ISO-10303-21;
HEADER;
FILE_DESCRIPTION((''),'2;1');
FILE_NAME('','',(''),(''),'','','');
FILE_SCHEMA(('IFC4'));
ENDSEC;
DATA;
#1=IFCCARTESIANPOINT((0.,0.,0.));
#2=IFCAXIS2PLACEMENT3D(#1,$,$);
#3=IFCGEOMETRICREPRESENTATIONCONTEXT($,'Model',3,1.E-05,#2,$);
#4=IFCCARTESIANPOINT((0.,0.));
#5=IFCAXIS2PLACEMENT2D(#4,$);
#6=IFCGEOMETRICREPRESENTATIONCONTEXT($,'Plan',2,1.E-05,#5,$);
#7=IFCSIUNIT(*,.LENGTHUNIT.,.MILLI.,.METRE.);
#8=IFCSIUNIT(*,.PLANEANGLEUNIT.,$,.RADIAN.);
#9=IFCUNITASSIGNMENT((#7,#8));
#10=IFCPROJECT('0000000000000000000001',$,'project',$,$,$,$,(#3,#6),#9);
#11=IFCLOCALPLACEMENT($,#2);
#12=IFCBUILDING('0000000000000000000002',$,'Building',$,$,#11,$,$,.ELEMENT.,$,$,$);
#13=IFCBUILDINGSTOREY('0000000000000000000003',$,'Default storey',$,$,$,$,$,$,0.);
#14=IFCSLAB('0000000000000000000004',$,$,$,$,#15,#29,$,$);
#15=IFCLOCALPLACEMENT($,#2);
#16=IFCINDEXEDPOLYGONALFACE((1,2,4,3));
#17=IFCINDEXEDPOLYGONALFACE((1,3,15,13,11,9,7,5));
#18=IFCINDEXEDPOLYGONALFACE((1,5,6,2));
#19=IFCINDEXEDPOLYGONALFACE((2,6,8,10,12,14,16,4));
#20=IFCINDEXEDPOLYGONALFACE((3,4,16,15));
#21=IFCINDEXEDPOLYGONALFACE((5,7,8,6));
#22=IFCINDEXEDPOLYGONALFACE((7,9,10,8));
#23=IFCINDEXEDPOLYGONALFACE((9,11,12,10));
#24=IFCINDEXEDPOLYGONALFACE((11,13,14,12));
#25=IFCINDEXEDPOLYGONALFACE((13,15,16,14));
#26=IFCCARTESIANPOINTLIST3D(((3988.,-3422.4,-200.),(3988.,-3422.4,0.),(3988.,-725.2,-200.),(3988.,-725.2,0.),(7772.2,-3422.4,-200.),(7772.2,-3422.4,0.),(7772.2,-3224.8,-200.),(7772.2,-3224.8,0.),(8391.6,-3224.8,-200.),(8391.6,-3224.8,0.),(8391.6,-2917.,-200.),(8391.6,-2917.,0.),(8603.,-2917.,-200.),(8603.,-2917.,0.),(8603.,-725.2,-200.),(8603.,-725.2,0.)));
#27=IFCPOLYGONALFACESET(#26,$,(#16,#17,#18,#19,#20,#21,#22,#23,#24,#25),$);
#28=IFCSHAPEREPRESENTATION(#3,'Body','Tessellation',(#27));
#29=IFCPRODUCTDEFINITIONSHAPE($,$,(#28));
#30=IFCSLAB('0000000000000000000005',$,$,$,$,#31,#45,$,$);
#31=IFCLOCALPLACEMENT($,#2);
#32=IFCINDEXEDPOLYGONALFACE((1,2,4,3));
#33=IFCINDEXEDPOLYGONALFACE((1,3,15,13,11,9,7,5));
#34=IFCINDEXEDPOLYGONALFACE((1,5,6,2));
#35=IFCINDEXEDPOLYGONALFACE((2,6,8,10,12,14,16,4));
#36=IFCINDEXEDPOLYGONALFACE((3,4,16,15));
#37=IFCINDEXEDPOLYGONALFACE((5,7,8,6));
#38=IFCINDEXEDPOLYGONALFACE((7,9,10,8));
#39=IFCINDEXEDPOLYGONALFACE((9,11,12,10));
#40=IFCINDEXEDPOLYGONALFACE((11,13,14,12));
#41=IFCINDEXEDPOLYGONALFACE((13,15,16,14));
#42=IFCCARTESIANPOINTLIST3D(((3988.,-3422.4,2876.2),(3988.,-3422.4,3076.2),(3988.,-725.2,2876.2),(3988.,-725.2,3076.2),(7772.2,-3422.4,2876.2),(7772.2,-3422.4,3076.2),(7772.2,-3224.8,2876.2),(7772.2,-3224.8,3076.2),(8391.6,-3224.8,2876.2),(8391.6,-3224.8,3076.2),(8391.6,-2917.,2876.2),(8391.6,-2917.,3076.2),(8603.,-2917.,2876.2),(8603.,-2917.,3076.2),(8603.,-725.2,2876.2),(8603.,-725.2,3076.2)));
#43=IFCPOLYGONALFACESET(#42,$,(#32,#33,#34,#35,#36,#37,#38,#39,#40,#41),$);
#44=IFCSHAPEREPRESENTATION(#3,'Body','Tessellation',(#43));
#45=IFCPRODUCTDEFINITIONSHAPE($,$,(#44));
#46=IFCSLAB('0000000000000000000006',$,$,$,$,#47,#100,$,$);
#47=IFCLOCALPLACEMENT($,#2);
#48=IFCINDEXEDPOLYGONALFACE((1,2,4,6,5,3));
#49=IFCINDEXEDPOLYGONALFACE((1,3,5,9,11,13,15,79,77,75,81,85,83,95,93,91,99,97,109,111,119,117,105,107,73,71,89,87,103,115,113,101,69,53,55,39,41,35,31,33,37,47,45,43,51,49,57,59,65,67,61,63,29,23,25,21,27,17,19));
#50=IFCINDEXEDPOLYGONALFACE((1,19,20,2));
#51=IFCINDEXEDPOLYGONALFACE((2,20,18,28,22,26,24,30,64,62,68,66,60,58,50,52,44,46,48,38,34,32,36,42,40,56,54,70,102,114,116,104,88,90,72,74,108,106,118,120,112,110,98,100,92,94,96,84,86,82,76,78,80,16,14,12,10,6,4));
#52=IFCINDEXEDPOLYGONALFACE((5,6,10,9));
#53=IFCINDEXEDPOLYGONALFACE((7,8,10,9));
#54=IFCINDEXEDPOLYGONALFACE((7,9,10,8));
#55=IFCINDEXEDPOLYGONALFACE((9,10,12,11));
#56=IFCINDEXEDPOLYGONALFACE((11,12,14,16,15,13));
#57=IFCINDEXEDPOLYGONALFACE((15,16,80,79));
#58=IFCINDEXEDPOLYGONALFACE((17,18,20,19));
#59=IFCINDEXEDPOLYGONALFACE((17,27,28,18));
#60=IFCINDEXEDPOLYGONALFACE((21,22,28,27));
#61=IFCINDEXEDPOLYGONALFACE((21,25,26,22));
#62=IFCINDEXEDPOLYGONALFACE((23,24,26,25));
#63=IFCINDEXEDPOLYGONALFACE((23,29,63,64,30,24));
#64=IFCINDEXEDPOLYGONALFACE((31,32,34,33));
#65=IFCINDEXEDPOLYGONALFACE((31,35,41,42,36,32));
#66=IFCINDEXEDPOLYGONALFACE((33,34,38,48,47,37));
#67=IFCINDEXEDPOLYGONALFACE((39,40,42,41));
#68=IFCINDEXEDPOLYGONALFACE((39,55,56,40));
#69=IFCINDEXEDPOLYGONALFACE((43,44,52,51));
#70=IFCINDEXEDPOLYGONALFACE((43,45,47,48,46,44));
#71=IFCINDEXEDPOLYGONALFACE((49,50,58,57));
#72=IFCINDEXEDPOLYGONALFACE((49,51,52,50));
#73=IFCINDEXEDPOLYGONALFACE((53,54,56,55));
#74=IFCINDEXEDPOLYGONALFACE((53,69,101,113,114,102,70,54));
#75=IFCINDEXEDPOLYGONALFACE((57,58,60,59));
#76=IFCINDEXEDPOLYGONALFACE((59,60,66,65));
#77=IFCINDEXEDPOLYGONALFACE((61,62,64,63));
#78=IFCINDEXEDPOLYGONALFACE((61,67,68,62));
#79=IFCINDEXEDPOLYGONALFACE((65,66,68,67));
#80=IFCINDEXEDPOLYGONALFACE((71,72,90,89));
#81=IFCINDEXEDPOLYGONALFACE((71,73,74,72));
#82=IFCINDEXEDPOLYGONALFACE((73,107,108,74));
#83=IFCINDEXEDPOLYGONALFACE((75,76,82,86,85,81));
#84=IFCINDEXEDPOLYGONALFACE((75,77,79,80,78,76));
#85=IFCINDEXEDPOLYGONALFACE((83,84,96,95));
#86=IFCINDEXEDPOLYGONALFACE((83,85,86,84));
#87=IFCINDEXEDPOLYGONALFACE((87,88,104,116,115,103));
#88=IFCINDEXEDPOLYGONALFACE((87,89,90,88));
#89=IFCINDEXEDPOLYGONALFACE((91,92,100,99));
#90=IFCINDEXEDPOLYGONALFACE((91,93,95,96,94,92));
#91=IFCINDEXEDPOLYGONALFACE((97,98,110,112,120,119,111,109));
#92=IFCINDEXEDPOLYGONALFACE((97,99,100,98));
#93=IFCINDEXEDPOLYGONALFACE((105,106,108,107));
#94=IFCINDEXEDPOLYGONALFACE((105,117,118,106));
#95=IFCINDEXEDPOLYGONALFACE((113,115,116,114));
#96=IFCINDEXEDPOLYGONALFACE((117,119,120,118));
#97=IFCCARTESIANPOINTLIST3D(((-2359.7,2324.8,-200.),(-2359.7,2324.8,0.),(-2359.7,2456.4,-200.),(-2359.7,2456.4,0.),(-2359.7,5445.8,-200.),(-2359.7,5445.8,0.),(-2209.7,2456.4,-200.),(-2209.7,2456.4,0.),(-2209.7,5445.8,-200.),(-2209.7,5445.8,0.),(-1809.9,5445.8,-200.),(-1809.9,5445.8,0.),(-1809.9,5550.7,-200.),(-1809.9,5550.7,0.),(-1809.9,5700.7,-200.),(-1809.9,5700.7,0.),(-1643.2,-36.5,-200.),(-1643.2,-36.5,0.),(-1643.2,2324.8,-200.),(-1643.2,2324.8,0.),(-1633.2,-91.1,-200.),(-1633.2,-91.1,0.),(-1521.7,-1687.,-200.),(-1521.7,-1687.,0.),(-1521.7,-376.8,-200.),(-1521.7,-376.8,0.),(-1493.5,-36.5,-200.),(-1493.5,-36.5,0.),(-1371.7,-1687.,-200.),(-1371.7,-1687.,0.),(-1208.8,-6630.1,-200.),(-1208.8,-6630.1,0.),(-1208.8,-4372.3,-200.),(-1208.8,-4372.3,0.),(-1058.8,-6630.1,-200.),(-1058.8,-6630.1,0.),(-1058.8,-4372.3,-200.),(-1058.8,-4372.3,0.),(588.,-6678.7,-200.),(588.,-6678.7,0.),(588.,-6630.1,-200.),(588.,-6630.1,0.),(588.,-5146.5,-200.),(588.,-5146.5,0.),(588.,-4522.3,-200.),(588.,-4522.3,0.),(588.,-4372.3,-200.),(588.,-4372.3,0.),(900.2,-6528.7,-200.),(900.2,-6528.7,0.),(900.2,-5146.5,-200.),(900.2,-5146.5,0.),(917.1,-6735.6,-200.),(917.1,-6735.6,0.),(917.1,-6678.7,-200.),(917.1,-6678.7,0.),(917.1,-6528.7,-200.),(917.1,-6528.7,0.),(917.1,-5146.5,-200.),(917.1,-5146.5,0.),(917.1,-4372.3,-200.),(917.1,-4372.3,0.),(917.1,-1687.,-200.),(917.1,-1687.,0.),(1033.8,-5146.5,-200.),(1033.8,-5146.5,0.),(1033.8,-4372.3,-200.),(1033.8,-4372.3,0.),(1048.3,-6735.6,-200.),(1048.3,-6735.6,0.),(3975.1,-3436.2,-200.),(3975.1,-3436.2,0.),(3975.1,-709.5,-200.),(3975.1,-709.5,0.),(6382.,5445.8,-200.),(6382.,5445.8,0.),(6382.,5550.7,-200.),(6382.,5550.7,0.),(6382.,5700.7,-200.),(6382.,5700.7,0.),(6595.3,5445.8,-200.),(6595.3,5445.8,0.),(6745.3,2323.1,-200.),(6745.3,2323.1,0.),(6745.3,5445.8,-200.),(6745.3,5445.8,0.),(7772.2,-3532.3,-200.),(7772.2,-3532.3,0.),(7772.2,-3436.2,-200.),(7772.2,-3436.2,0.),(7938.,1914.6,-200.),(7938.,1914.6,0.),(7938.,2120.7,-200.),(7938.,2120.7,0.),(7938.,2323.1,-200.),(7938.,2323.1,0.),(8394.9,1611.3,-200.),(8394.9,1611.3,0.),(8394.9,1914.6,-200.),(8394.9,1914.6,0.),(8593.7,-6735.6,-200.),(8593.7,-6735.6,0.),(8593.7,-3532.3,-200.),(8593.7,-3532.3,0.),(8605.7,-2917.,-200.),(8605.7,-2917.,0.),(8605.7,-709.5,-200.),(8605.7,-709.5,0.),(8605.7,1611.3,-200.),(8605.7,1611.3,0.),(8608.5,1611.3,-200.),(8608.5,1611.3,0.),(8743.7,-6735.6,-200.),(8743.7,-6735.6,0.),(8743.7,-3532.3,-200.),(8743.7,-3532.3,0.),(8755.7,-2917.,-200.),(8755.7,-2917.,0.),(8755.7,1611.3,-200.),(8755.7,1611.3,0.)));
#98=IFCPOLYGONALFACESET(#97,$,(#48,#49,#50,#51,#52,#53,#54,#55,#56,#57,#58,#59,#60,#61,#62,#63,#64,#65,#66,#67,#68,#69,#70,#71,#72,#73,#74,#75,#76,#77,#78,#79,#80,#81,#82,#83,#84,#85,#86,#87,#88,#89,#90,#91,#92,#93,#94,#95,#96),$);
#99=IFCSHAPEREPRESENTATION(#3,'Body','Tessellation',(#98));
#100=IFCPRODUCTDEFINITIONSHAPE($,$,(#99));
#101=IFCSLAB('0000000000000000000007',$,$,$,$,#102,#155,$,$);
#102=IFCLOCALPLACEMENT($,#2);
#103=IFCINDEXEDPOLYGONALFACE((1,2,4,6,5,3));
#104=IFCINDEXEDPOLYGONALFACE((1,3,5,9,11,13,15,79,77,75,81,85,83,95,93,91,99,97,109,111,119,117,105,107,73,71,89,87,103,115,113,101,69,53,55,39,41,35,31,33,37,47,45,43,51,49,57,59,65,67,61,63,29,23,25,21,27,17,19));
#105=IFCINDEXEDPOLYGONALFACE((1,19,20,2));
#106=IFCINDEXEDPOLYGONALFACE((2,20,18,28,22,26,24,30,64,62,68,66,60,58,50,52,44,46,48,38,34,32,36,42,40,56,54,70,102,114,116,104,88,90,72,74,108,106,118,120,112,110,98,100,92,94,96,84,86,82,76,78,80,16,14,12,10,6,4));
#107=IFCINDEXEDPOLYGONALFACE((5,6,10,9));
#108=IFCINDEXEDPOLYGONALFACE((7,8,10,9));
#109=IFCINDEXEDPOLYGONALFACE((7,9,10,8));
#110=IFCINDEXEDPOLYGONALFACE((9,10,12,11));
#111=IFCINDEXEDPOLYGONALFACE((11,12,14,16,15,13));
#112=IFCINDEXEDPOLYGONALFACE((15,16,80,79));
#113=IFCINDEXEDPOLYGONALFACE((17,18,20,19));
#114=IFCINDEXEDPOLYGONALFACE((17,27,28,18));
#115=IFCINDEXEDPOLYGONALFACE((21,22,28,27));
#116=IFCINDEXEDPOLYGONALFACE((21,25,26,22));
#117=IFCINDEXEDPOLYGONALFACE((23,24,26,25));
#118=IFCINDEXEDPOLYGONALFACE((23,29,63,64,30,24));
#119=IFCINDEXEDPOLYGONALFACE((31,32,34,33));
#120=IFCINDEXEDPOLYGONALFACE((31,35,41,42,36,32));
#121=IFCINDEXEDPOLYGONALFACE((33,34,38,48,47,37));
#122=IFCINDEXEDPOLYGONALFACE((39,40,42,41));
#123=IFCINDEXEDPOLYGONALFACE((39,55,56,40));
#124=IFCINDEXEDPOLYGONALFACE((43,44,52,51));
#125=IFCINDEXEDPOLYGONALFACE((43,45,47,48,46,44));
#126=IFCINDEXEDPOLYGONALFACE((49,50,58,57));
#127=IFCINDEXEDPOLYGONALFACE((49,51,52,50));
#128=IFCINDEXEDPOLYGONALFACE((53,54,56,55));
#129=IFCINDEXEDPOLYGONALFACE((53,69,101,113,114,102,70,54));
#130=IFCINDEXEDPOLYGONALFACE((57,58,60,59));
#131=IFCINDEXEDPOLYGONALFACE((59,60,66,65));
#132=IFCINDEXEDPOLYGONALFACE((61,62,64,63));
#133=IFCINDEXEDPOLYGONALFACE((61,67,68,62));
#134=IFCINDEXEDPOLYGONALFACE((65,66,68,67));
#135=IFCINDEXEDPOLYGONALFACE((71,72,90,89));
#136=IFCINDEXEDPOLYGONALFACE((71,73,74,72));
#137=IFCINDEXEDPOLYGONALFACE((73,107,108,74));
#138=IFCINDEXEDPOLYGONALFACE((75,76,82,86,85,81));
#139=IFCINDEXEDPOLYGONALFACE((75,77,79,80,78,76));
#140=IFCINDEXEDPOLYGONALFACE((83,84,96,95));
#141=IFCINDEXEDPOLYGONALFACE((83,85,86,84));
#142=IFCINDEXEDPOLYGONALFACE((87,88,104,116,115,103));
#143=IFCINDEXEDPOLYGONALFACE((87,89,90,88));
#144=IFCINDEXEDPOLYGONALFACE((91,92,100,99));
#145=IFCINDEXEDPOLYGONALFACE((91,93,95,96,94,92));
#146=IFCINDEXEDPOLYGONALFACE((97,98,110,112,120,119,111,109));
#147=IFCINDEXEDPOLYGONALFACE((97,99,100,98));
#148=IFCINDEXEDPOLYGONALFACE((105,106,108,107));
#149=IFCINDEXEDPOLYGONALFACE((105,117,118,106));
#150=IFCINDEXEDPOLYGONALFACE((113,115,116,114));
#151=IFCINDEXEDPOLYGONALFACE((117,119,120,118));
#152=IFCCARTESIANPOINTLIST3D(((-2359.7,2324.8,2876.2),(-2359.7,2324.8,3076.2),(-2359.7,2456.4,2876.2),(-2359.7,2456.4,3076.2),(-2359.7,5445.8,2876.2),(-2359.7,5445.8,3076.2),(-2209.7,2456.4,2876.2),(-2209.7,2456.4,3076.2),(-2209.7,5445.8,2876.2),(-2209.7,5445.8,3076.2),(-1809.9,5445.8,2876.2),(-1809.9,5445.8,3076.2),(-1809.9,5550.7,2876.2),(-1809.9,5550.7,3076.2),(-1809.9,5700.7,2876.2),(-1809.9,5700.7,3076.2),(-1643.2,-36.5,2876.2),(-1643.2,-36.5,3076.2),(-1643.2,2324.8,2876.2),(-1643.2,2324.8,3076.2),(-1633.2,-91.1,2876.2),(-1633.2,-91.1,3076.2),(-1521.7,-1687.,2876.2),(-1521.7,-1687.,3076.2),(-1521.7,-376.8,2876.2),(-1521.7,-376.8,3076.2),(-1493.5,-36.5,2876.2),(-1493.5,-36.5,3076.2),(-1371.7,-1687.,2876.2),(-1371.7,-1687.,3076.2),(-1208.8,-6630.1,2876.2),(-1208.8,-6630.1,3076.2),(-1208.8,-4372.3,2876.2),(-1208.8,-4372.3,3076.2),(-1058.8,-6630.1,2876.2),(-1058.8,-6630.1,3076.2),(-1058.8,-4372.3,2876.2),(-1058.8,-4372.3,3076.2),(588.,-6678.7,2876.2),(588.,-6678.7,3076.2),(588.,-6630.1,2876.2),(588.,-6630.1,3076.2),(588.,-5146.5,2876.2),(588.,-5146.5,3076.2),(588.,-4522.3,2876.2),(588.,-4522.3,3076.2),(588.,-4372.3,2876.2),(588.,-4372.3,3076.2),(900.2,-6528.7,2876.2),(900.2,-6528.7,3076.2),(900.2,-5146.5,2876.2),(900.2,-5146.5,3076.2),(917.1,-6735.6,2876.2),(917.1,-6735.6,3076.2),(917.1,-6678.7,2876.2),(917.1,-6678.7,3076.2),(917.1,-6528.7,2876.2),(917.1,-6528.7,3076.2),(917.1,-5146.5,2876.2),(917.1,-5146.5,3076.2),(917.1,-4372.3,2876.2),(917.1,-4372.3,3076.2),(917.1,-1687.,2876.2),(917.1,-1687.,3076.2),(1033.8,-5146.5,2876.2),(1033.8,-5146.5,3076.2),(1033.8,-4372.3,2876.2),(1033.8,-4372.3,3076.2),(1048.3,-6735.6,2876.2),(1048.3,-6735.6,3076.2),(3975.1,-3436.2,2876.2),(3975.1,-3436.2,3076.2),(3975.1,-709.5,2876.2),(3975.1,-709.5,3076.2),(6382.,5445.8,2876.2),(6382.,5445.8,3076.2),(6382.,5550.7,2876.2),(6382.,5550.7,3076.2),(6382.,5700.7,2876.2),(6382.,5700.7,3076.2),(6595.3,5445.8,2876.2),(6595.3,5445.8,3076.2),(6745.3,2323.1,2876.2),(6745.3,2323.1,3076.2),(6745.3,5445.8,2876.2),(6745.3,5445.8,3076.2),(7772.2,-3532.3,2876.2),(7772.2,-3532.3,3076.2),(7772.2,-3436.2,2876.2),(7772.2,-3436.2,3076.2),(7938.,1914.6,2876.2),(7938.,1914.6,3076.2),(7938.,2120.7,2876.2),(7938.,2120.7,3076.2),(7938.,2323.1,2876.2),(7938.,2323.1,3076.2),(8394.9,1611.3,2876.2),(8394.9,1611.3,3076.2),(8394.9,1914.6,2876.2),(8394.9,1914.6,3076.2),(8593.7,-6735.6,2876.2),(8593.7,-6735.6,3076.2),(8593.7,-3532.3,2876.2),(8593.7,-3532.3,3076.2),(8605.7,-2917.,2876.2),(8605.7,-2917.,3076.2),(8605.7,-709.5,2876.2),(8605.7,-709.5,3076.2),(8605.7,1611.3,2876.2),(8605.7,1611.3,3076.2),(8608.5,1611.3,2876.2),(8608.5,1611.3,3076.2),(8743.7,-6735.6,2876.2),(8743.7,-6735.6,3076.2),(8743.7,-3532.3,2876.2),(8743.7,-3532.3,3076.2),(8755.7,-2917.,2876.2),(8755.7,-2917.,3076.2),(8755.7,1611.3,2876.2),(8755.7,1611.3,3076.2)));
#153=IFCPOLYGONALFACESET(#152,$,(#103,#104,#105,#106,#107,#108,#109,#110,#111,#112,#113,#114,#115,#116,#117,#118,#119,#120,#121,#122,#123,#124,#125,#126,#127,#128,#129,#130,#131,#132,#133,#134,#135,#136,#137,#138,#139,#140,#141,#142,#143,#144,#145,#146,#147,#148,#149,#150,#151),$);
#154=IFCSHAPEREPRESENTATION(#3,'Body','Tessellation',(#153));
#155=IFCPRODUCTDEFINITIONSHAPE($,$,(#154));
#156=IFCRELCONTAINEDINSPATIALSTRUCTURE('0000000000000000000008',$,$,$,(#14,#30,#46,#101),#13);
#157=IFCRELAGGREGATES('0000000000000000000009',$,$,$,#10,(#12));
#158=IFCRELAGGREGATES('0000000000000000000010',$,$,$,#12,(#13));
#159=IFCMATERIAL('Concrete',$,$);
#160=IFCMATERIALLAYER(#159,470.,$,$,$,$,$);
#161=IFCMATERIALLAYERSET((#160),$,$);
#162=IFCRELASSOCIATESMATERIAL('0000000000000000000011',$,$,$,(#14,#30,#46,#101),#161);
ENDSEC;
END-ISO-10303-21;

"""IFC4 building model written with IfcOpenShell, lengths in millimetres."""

from ifc_helpers import new_model, si_unit, frame, origin, origin_2d, place, context, project, spatial, polyline, outline, extrude, material, layer, layer_set, layer_usage, element, save


model = new_model("IFC4")

# Units and contexts
model_context = context("Model", 3, precision=1e-05, world=origin())
plan_context = context("Plan", 2, precision=1e-05, world=origin_2d())
ifc_project = project(units=[si_unit("LENGTHUNIT", "METRE", prefix="MILLI"), si_unit("PLANEANGLEUNIT", "RADIAN")], contexts=[model_context, plan_context])

# Building, storey
placement = place(None, origin())
building = spatial("IfcBuilding", under=ifc_project, at=placement, Name="Building", CompositionType="ELEMENT")
storey = spatial("IfcBuildingStorey", under=building, Name="Default storey", Elevation=0.0)

# Slabs
ifc_material_1 = material(Name="Concrete")
ifc_layer_1 = layer(ifc_material_1, 470.0)
ifc_layer_set_1 = layer_set([ifc_layer_1])
ifc_layer_usage_1 = layer_usage(ifc_layer_set_1, "AXIS3", "POSITIVE", 0.0)
element("IfcSlab", 1, at=placement, inside=storey, material=ifc_layer_usage_1, context=model_context, shape_type="SweptSolid", body=[
    extrude(outline(polyline([(3988.0, -3422.4), (7772.2, -3422.4), (7772.2, -3224.8), (8391.6, -3224.8), (8391.6, -2917.0), (8603.0, -2917.0), (8603.0, -725.2), (3988.0, -725.2), (3988.0, -3422.4)])), frame((0.0, 0.0, -200.0), z_axis=(0.0, 0.0, 1000.0), x_axis=(1000.0, 0.0, 0.0)), (0.0, 0.0, 1.0), 200.0),
])
element("IfcSlab", 2, at=placement, inside=storey, material=ifc_layer_usage_1, context=model_context, shape_type="SweptSolid", body=[
    extrude(outline(polyline([(3988.0, -3422.4), (7772.2, -3422.4), (7772.2, -3224.8), (8391.6, -3224.8), (8391.6, -2917.0), (8603.0, -2917.0), (8603.0, -725.2), (3988.0, -725.2), (3988.0, -3422.4)])), frame((0.0, 0.0, 3076.2), z_axis=(0.0, 0.0, 1000.0), x_axis=(1000.0, 0.0, 0.0)), (0.0, 0.0, -1.0), 200.0),
])
element("IfcSlab", 3, at=placement, inside=storey, material=ifc_layer_usage_1, context=model_context, shape_type="SweptSolid", body=[
    extrude(outline(polyline([(8605.7, -2917.0), (8755.7, -2917.0), (8755.7, 1611.3), (8608.5, 1611.3), (8605.7, 1611.3), (8394.9, 1611.3), (8394.9, 1914.6), (7938.0, 1914.6), (7938.0, 2120.7), (7938.0, 2323.1), (6745.3, 2323.1), (6745.3, 5445.8), (6595.3, 5445.8), (6595.3, 5445.8), (6382.0, 5445.8), (6382.0, 5550.7), (6382.0, 5700.7), (-1809.9, 5700.7), (-1809.9, 5550.7), (-1809.9, 5445.8), (-2209.7, 5445.8), (-2209.7, 2456.4), (-2209.7, 2456.4), (-2209.7, 5445.8), (-2359.7, 5445.8), (-2359.7, 2456.4), (-2359.7, 2324.8), (-1643.2, 2324.8), (-1643.2, -36.5), (-1493.5, -36.5), (-1633.2, -91.1), (-1521.7, -376.8), (-1521.7, -1687.0), (-1371.7, -1687.0), (917.1, -1687.0), (917.1, -4372.3), (1033.8, -4372.3), (1033.8, -5146.5), (917.1, -5146.5), (917.1, -6528.7), (900.2, -6528.7), (900.2, -5146.5), (588.0, -5146.5), (588.0, -4522.3), (588.0, -4372.3), (-1058.8, -4372.3), (-1208.8, -4372.3), (-1208.8, -6630.1), (-1058.8, -6630.1), (588.0, -6630.1), (588.0, -6678.7), (917.1, -6678.7), (917.1, -6735.6), (1048.3, -6735.6), (8593.7, -6735.6), (8743.7, -6735.6), (8743.7, -3532.3), (8593.7, -3532.3), (8593.7, -3532.3), (7772.2, -3532.3), (7772.2, -3436.2), (3975.1, -3436.2), (3975.1, -709.5), (8605.7, -709.5), (8605.7, -2917.0)])), frame((0.0, 0.0, -200.0), z_axis=(0.0, 0.0, 1000.0), x_axis=(1000.0, 0.0, 0.0)), (0.0, 0.0, 1.0), 200.0),
])
element("IfcSlab", 4, at=placement, inside=storey, material=ifc_layer_usage_1, context=model_context, shape_type="SweptSolid", body=[
    extrude(outline(polyline([(8605.7, -2917.0), (8755.7, -2917.0), (8755.7, 1611.3), (8608.5, 1611.3), (8605.7, 1611.3), (8394.9, 1611.3), (8394.9, 1914.6), (7938.0, 1914.6), (7938.0, 2120.7), (7938.0, 2323.1), (6745.3, 2323.1), (6745.3, 5445.8), (6595.3, 5445.8), (6595.3, 5445.8), (6382.0, 5445.8), (6382.0, 5550.7), (6382.0, 5700.7), (-1809.9, 5700.7), (-1809.9, 5550.7), (-1809.9, 5445.8), (-2209.7, 5445.8), (-2209.7, 2456.4), (-2209.7, 2456.4), (-2209.7, 5445.8), (-2359.7, 5445.8), (-2359.7, 2456.4), (-2359.7, 2324.8), (-1643.2, 2324.8), (-1643.2, -36.5), (-1493.5, -36.5), (-1633.2, -91.1), (-1521.7, -376.8), (-1521.7, -1687.0), (-1371.7, -1687.0), (917.1, -1687.0), (917.1, -4372.3), (1033.8, -4372.3), (1033.8, -5146.5), (917.1, -5146.5), (917.1, -6528.7), (900.2, -6528.7), (900.2, -5146.5), (588.0, -5146.5), (588.0, -4522.3), (588.0, -4372.3), (-1058.8, -4372.3), (-1208.8, -4372.3), (-1208.8, -6630.1), (-1058.8, -6630.1), (588.0, -6630.1), (588.0, -6678.7), (917.1, -6678.7), (917.1, -6735.6), (1048.3, -6735.6), (8593.7, -6735.6), (8743.7, -6735.6), (8743.7, -3532.3), (8593.7, -3532.3), (8593.7, -3532.3), (7772.2, -3532.3), (7772.2, -3436.2), (3975.1, -3436.2), (3975.1, -709.5), (8605.7, -709.5), (8605.7, -2917.0)])), frame((0.0, 0.0, 3076.2), z_axis=(0.0, 0.0, 1000.0), x_axis=(1000.0, 0.0, 0.0)), (0.0, 0.0, -1.0), 200.0),
])

save(model, "model.ifc")
